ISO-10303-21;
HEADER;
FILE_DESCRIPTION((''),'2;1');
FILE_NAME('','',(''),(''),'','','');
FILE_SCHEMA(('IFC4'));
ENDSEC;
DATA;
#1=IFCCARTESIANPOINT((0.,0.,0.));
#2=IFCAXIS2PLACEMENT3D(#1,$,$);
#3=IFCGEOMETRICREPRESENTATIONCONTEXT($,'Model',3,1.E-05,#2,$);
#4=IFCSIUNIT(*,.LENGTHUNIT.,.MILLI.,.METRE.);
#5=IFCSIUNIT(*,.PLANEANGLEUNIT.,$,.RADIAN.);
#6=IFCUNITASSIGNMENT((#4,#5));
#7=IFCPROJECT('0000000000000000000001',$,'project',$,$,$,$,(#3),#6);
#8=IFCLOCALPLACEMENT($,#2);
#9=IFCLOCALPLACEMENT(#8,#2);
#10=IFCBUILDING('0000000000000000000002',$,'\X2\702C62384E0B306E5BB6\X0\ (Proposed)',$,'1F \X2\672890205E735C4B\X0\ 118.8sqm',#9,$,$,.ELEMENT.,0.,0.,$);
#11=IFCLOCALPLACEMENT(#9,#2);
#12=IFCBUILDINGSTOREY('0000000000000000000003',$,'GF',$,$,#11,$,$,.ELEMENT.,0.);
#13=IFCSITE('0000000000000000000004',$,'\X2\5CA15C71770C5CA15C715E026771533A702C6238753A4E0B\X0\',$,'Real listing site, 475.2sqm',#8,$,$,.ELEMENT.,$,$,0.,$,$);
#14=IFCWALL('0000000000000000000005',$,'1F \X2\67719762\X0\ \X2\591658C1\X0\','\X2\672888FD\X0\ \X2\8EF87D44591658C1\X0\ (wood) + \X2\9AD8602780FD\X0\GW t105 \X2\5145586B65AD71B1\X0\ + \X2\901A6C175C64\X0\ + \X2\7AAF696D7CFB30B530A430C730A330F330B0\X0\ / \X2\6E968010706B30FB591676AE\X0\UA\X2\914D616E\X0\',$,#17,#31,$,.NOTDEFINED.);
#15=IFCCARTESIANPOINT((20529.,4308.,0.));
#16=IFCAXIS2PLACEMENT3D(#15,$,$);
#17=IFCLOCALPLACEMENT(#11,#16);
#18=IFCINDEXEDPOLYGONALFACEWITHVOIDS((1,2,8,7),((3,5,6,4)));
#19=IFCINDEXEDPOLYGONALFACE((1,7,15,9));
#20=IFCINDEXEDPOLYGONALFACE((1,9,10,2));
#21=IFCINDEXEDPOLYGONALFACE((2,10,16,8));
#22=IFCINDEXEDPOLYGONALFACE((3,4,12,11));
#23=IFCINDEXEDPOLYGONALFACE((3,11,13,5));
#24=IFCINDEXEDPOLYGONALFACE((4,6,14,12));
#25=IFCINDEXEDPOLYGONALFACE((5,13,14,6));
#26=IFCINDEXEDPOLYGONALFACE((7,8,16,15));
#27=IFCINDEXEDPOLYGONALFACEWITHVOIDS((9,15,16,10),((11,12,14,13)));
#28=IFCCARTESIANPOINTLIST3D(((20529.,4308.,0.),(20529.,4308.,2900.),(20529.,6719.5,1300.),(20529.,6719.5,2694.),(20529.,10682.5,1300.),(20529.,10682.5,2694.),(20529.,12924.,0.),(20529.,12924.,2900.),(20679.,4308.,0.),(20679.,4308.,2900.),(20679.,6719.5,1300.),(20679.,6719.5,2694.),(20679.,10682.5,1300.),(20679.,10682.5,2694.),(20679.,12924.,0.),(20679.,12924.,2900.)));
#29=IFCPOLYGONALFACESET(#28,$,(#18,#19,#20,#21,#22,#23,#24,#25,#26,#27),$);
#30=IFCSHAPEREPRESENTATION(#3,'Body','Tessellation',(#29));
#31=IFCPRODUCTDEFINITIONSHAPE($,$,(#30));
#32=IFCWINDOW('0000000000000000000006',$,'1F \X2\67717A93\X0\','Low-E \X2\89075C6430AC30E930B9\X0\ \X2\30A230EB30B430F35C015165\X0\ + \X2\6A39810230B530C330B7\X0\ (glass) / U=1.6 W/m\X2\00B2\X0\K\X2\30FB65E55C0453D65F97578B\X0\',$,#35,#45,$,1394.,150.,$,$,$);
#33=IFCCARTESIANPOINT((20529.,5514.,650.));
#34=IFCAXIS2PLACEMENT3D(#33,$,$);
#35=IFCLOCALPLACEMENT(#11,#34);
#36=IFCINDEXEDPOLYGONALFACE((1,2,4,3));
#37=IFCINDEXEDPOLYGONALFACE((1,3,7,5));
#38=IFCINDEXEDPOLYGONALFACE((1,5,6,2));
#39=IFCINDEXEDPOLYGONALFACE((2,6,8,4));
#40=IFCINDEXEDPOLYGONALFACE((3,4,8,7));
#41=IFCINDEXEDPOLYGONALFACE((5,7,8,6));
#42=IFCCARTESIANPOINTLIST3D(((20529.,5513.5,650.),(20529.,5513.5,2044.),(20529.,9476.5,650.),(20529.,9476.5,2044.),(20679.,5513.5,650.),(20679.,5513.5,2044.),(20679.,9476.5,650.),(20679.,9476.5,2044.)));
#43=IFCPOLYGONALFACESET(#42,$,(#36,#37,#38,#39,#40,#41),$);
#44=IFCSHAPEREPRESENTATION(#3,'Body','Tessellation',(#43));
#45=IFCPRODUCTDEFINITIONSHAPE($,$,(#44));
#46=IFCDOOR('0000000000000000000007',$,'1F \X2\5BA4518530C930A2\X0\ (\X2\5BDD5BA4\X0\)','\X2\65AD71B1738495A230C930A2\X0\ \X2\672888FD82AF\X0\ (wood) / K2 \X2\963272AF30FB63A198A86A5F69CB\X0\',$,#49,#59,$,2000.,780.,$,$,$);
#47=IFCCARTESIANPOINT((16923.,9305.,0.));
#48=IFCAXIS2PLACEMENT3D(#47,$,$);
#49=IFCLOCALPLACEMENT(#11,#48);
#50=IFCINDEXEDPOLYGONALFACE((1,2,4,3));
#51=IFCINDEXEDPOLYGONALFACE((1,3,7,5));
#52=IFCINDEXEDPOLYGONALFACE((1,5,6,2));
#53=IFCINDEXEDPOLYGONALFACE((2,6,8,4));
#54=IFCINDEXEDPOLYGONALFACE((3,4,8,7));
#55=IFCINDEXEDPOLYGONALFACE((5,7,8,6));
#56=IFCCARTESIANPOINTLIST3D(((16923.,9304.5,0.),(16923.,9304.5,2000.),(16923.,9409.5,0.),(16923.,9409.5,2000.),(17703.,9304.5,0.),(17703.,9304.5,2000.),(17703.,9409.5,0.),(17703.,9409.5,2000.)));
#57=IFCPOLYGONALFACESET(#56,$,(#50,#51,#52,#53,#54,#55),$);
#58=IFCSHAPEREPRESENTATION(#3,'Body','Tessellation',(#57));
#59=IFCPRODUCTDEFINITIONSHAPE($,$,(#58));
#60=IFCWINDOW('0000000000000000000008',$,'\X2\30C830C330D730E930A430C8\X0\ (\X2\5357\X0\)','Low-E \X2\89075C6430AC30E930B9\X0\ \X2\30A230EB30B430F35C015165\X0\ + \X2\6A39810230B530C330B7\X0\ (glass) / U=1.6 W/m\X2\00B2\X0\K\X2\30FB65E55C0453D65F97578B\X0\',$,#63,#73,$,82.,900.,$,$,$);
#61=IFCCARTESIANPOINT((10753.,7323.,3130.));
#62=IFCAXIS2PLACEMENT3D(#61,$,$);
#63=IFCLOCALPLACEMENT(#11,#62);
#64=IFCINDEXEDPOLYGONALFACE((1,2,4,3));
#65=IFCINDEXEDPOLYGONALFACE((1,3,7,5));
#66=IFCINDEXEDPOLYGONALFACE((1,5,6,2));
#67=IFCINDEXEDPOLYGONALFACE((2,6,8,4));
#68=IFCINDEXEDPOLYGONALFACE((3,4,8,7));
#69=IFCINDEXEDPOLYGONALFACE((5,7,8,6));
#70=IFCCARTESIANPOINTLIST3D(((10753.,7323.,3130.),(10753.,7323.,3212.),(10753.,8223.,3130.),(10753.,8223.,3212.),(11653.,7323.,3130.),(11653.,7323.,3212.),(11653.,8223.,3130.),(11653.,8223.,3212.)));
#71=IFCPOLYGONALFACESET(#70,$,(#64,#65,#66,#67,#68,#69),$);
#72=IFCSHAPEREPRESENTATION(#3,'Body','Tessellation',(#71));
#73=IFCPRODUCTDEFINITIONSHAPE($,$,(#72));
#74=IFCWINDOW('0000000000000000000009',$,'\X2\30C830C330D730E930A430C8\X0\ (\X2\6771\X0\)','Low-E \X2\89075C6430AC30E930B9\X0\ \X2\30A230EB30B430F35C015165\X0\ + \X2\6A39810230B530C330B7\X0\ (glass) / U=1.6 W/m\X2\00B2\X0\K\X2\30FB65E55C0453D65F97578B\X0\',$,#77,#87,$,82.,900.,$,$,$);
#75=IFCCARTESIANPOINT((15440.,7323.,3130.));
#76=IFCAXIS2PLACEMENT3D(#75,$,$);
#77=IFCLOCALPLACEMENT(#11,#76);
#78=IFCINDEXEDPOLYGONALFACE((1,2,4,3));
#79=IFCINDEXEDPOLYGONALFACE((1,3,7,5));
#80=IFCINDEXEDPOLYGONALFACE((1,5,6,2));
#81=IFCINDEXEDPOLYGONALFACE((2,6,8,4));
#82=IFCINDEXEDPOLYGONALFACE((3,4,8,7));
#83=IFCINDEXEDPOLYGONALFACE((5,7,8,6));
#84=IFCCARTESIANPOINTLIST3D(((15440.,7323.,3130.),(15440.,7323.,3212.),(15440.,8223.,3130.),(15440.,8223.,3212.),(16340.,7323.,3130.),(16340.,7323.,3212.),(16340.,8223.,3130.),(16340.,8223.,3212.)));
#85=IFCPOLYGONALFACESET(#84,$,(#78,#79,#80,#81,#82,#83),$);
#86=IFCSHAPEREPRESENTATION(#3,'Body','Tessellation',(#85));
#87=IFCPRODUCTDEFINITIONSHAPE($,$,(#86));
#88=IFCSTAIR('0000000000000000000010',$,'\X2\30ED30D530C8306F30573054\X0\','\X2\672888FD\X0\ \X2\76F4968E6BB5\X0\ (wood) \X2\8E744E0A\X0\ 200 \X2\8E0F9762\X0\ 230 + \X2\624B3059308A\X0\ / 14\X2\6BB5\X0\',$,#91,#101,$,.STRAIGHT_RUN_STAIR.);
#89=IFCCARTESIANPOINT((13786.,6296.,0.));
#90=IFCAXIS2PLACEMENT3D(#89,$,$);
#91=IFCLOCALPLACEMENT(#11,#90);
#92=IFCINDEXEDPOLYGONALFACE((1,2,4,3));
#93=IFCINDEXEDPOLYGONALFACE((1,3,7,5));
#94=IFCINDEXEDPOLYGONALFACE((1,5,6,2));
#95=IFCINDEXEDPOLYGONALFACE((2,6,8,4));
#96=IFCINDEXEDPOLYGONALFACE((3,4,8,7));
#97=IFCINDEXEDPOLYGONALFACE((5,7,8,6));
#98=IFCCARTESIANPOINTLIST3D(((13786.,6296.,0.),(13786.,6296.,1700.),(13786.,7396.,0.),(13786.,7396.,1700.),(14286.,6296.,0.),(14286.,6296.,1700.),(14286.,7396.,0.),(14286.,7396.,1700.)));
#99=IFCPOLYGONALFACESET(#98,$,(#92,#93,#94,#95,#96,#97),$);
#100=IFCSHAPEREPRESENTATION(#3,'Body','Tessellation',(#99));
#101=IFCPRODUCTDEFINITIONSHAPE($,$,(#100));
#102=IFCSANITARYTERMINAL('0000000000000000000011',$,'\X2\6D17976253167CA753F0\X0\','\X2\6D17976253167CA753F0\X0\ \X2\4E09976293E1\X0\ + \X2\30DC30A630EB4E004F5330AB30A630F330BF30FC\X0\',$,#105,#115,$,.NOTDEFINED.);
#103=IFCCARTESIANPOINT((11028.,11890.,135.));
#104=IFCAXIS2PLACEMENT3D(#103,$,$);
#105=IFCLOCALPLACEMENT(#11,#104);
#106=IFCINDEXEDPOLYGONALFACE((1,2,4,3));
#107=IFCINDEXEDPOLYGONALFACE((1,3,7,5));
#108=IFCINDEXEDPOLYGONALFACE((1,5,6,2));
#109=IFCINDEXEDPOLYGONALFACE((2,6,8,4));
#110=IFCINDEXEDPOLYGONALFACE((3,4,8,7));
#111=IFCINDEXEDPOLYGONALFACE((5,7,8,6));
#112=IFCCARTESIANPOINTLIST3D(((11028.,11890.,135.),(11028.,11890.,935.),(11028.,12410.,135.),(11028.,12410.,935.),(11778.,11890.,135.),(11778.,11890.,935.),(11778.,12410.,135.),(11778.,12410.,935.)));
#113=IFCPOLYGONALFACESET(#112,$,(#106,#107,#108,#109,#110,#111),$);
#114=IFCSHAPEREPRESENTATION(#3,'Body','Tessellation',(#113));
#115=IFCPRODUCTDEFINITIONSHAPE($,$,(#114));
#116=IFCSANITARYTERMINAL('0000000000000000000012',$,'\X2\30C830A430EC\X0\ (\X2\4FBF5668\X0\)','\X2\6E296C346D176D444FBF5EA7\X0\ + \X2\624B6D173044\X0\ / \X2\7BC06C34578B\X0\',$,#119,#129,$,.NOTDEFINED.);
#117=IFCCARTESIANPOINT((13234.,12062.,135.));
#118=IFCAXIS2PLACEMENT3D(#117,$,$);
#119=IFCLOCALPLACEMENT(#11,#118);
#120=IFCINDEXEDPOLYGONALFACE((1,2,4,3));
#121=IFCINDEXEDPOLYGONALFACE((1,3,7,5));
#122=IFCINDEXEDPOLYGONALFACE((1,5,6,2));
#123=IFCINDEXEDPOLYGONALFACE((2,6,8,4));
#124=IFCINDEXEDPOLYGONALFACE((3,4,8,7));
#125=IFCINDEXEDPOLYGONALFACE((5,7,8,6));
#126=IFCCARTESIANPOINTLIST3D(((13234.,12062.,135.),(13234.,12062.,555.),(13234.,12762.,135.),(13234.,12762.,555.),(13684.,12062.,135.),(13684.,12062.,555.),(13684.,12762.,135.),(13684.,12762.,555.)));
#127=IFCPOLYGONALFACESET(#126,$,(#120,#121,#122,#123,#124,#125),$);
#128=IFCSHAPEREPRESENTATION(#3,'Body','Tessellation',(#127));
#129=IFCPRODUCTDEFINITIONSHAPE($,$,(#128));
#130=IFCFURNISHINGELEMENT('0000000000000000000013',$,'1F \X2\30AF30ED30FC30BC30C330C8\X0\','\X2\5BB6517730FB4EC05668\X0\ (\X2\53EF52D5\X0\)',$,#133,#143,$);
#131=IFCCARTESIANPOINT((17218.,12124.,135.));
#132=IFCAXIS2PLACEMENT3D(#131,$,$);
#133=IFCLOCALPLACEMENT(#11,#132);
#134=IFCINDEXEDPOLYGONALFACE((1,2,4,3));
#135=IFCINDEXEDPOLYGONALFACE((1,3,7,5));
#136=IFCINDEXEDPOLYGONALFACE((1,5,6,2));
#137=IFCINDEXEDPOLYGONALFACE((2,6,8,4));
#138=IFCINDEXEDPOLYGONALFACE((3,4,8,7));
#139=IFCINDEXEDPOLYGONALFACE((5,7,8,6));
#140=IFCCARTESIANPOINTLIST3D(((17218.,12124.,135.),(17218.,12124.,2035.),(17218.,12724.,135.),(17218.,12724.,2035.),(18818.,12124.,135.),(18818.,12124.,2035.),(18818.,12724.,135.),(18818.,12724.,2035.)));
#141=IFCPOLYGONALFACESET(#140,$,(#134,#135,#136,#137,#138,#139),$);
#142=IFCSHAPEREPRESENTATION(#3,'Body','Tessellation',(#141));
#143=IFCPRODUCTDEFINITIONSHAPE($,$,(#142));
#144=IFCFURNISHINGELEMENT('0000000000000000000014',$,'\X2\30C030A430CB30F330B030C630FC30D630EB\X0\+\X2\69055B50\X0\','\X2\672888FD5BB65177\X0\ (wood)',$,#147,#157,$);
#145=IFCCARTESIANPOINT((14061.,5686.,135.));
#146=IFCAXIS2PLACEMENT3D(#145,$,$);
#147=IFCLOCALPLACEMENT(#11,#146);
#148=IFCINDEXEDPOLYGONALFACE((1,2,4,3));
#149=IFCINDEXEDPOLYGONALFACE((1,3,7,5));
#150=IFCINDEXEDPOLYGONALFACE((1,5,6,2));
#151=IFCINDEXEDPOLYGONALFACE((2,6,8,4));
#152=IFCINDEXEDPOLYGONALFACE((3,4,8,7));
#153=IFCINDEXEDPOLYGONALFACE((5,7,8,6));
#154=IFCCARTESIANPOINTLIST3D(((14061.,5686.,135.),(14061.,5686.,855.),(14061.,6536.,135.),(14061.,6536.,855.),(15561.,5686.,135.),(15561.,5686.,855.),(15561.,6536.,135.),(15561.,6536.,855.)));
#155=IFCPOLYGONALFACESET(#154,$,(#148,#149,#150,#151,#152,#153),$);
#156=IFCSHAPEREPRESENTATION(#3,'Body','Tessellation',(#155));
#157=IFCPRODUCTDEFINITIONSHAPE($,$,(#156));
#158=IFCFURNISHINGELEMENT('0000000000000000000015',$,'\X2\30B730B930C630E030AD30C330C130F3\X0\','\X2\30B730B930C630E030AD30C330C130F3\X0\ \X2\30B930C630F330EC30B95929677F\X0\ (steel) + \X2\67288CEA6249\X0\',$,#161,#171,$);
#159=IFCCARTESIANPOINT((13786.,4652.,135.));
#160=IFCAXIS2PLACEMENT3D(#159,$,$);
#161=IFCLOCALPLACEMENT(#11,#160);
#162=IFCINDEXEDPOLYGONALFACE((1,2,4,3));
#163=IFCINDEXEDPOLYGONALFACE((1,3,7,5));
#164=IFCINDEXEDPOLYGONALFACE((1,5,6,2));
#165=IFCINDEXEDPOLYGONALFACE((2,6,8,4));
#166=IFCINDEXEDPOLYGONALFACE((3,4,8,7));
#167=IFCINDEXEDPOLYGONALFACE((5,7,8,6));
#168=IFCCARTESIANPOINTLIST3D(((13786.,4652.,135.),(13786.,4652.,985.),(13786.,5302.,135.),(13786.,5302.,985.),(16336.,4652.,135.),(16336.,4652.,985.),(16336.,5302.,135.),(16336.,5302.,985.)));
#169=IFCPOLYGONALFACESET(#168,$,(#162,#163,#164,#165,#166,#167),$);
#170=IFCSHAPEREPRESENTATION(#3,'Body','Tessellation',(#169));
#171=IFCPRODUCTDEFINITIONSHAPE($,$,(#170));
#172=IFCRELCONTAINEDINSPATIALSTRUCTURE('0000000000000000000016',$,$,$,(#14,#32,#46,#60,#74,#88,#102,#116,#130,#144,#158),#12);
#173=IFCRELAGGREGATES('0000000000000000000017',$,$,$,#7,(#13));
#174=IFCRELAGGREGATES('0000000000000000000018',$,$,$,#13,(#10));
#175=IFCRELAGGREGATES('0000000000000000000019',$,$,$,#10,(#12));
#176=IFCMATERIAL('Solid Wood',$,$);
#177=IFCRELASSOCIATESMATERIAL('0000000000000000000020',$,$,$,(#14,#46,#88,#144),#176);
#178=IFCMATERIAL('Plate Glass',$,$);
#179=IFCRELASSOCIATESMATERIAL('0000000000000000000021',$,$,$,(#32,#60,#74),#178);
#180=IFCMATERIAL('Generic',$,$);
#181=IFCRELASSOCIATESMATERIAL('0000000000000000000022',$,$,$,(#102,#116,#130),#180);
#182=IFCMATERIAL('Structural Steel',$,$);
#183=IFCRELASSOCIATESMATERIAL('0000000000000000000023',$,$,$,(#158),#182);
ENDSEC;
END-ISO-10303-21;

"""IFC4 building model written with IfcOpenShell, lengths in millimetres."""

from ifc_helpers import new_model, si_unit, frame, frame_2d, origin, place, context, project, spatial, rectangle, extrude, material, element, fill, save


model = new_model("IFC4")

# Units and contexts
model_context = context("Model", 3, precision=1e-05, world=origin())
ifc_project = project(units=[si_unit("LENGTHUNIT", "METRE", prefix="MILLI"), si_unit("PLANEANGLEUNIT", "RADIAN")], contexts=[model_context])

# Site, building, storey
site_placement = place(None, origin())
site = spatial("IfcSite", under=ifc_project, at=site_placement, Name="岡山県岡山市東区瀬戸町下", ObjectType="Real listing site, 475.2sqm", CompositionType="ELEMENT", RefElevation=0.0)
building_placement = place(site_placement, origin())
building = spatial("IfcBuilding", under=site, at=building_placement, Name="瀬戸下の家 (Proposed)", ObjectType="1F 木造平屋 118.8sqm", CompositionType="ELEMENT", ElevationOfRefHeight=0.0, ElevationOfTerrain=0.0)
storey_placement = place(building_placement, origin())
storey = spatial("IfcBuildingStorey", under=building, at=storey_placement, Name="GF", CompositionType="ELEMENT", Elevation=0.0)

# Wall, opening, window
ifc_material_1 = material(Name="Solid Wood")
wall_1_placement = place(storey_placement, frame((20529.0, 4308.0, 0.0)))
wall_1 = element("IfcWall", 1, at=wall_1_placement, inside=storey, material=ifc_material_1, Name="1F 東面 外壁", Description="木製 軸組外壁 (wood) + 高性能GW t105 充填断熱 + 通気層 + 窯業系サイディング / 準耐火・外皮UA配慮", PredefinedType="NOTDEFINED", context=model_context, shape_type="SweptSolid", body=[
    extrude(rectangle(XDim=150.0, YDim=8616.0, at=frame_2d((75.0, 4308.0))), frame((20529.0, 4308.0, 0.0)), (0.0, 0.0, 1.0), 2900.0),
])
opening_placement = place(storey_placement, frame((20529.0, 5514.0, 650.0)))
opening = element("IfcOpeningElement", 2, at=opening_placement, cuts=wall_1, PredefinedType="NOTDEFINED", context=model_context, shape_type="SweptSolid", body=[
    extrude(rectangle(XDim=150.0, YDim=3963.0, at=frame_2d((75.0, 1981.0))), frame((20529.0, 5514.0, 650.0)), (0.0, 0.0, 1.0), 1394.0),
])
ifc_material_2 = material(Name="Plate Glass")
window_1_placement = place(storey_placement, frame((20529.0, 5514.0, 650.0)))
window_1 = element("IfcWindow", 3, at=window_1_placement, inside=storey, material=ifc_material_2, Name="1F 東窓", Description="Low-E 複層ガラス アルゴン封入 + 樹脂サッシ (glass) / U=1.6 W/m²K・日射取得型", OverallHeight=1394.0, OverallWidth=150.0, context=model_context, shape_type="SweptSolid", body=[
    extrude(rectangle(XDim=150.0, YDim=3963.0, at=frame_2d((75.0, 1981.0))), frame((20529.0, 5514.0, 650.0)), (0.0, 0.0, 1.0), 1394.0),
])
fill(opening, window_1)

# Door
door_placement = place(storey_placement, frame((16923.0, 9305.0, 0.0)))
element("IfcDoor", 4, at=door_placement, inside=storey, material=ifc_material_1, Name="1F 室内ドア (寝室)", Description="断熱玄関ドア 木製芯 (wood) / K2 防犯・採風機構", OverallHeight=2000.0, OverallWidth=780.0, context=model_context, shape_type="SweptSolid", body=[
    extrude(rectangle(XDim=780.0, YDim=105.0, at=frame_2d((390.0, 52.0))), frame((16923.0, 9305.0, 0.0)), (0.0, 0.0, 1.0), 2000.0),
])

# Windows
window_2_placement = place(storey_placement, frame((10753.0, 7323.0, 3130.0)))
element("IfcWindow", 5, at=window_2_placement, inside=storey, material=ifc_material_2, Name="トップライト (南)", Description="Low-E 複層ガラス アルゴン封入 + 樹脂サッシ (glass) / U=1.6 W/m²K・日射取得型", OverallHeight=82.0, OverallWidth=900.0, context=model_context, shape_type="SweptSolid", body=[
    extrude(rectangle(XDim=900.0, YDim=900.0, at=frame_2d((450.0, 450.0))), frame((10753.0, 7323.0, 3130.0)), (0.0, 0.0, 1.0), 82.0),
])
window_3_placement = place(storey_placement, frame((15440.0, 7323.0, 3130.0)))
element("IfcWindow", 6, at=window_3_placement, inside=storey, material=ifc_material_2, Name="トップライト (東)", Description="Low-E 複層ガラス アルゴン封入 + 樹脂サッシ (glass) / U=1.6 W/m²K・日射取得型", OverallHeight=82.0, OverallWidth=900.0, context=model_context, shape_type="SweptSolid", body=[
    extrude(rectangle(XDim=900.0, YDim=900.0, at=frame_2d((450.0, 450.0))), frame((15440.0, 7323.0, 3130.0)), (0.0, 0.0, 1.0), 82.0),
])

# Stair
stair_placement = place(storey_placement, frame((13786.0, 6296.0, 0.0)))
element("IfcStair", 7, at=stair_placement, inside=storey, material=ifc_material_1, Name="ロフトはしご", Description="木製 直階段 (wood) 蹴上 200 踏面 230 + 手すり / 14段", PredefinedType="STRAIGHT_RUN_STAIR", context=model_context, shape_type="SweptSolid", body=[
    extrude(rectangle(XDim=500.0, YDim=1100.0, at=frame_2d((250.0, 550.0))), frame((13786.0, 6296.0, 0.0)), (0.0, 0.0, 1.0), 1700.0),
])

# Sanitary terminals
ifc_material_3 = material(Name="Generic")
sanitary_terminal_1_placement = place(storey_placement, frame((11028.0, 11890.0, 135.0)))
element("IfcSanitaryTerminal", 8, at=sanitary_terminal_1_placement, inside=storey, material=ifc_material_3, Name="洗面化粧台", Description="洗面化粧台 三面鏡 + ボウル一体カウンター", PredefinedType="NOTDEFINED", context=model_context, shape_type="SweptSolid", body=[
    extrude(rectangle(XDim=750.0, YDim=520.0, at=frame_2d((375.0, 260.0))), frame((11028.0, 11890.0, 135.0)), (0.0, 0.0, 1.0), 800.0),
])
sanitary_terminal_2_placement = place(storey_placement, frame((13234.0, 12062.0, 135.0)))
element("IfcSanitaryTerminal", 9, at=sanitary_terminal_2_placement, inside=storey, material=ifc_material_3, Name="トイレ (便器)", Description="温水洗浄便座 + 手洗い / 節水型", PredefinedType="NOTDEFINED", context=model_context, shape_type="SweptSolid", body=[
    extrude(rectangle(XDim=450.0, YDim=700.0, at=frame_2d((225.0, 350.0))), frame((13234.0, 12062.0, 135.0)), (0.0, 0.0, 1.0), 420.0),
])

# Furnishing elements
furnishing_1_placement = place(storey_placement, frame((17218.0, 12124.0, 135.0)))
element("IfcFurnishingElement", 10, at=furnishing_1_placement, inside=storey, material=ifc_material_3, Name="1F クローゼット", Description="家具・什器 (可動)", context=model_context, shape_type="SweptSolid", body=[
    extrude(rectangle(XDim=1600.0, YDim=600.0, at=frame_2d((800.0, 300.0))), frame((17218.0, 12124.0, 135.0)), (0.0, 0.0, 1.0), 1900.0),
])
furnishing_2_placement = place(storey_placement, frame((14061.0, 5686.0, 135.0)))
element("IfcFurnishingElement", 11, at=furnishing_2_placement, inside=storey, material=ifc_material_1, Name="ダイニングテーブル+椅子", Description="木製家具 (wood)", context=model_context, shape_type="SweptSolid", body=[
    extrude(rectangle(XDim=1500.0, YDim=850.0, at=frame_2d((750.0, 425.0))), frame((14061.0, 5686.0, 135.0)), (0.0, 0.0, 1.0), 720.0),
])
ifc_material_4 = material(Name="Structural Steel")
furnishing_3_placement = place(storey_placement, frame((13786.0, 4652.0, 135.0)))
element("IfcFurnishingElement", 12, at=furnishing_3_placement, inside=storey, material=ifc_material_4, Name="システムキッチン", Description="システムキッチン ステンレス天板 (steel) + 木質扉", context=model_context, shape_type="SweptSolid", body=[
    extrude(rectangle(XDim=2550.0, YDim=650.0, at=frame_2d((1275.0, 325.0))), frame((13786.0, 4652.0, 135.0)), (0.0, 0.0, 1.0), 850.0),
])

save(model, "model.ifc")
